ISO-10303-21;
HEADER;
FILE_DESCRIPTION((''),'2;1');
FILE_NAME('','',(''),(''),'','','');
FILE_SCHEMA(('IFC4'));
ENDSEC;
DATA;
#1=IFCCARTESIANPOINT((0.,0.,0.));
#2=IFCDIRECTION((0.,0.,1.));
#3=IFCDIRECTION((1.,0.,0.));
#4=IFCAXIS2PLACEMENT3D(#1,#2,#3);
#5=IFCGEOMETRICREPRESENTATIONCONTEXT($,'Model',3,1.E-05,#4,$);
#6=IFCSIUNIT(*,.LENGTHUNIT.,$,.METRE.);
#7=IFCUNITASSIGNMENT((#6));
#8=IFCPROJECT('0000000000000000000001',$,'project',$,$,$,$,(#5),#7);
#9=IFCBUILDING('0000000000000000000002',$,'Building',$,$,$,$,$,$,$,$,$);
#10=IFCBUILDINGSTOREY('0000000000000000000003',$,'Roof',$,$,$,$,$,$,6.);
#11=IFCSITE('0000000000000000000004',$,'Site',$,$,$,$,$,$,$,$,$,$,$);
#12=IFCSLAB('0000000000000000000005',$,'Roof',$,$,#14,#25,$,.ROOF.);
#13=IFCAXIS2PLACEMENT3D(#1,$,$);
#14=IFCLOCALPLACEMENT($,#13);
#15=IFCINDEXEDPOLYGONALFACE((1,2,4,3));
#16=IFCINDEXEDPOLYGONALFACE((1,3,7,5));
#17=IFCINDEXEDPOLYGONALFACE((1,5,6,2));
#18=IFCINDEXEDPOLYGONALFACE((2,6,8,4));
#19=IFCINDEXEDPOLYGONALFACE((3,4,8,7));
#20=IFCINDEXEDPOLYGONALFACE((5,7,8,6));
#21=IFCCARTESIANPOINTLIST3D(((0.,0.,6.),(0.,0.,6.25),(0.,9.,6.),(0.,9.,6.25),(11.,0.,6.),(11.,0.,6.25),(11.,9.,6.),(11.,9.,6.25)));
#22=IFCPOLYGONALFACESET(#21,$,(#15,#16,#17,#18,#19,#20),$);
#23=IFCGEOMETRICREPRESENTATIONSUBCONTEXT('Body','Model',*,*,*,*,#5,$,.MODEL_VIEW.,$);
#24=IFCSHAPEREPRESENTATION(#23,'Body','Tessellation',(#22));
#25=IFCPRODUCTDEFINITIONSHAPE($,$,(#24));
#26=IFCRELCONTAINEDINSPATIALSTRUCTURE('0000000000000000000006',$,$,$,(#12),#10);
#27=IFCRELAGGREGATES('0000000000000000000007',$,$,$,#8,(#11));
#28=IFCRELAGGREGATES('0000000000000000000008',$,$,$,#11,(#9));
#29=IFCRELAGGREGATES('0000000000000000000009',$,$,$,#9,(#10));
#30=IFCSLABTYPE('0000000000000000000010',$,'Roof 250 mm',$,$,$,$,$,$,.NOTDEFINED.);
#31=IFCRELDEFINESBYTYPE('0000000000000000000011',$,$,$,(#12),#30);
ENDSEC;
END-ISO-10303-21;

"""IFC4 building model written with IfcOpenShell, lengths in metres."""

from ifc_helpers import new_model, si_unit, frame, origin_with_axes, place, context, subcontext, project, spatial, indexed_curve, outline, extrude, type_object, element, save


model = new_model("IFC4")

# Units and contexts
model_context = context("Model", 3, precision=1e-05, world=origin_with_axes())
body_context = subcontext(model_context, "Body", "Model", "MODEL_VIEW")
ifc_project = project(units=[si_unit("LENGTHUNIT", "METRE")], contexts=[model_context])

# Site, building, storey
site = spatial("IfcSite", under=ifc_project, Name="Site")
building = spatial("IfcBuilding", under=site, Name="Building")
storey = spatial("IfcBuildingStorey", under=building, Name="Roof", Elevation=6.0)

# Slab
slab_type = type_object("IfcSlabType", Name="Roof 250 mm", PredefinedType="NOTDEFINED")
slab_placement = place(None, frame((0.0, 0.0, 6.0), z_axis=(0.0, 0.0, 1.0), x_axis=(1.0, 0.0, 0.0)))
element("IfcSlab", 1, at=slab_placement, inside=storey, type_object=slab_type, Name="Roof", PredefinedType="ROOF", context=body_context, shape_type="SweptSolid", body=[
    extrude(outline(indexed_curve([(0.0, 0.0), (11.0, 0.0), (11.0, 9.0), (0.0, 9.0)])), None, (0.0, 0.0, 1.0), 0.25),
])

save(model, "model.ifc")
